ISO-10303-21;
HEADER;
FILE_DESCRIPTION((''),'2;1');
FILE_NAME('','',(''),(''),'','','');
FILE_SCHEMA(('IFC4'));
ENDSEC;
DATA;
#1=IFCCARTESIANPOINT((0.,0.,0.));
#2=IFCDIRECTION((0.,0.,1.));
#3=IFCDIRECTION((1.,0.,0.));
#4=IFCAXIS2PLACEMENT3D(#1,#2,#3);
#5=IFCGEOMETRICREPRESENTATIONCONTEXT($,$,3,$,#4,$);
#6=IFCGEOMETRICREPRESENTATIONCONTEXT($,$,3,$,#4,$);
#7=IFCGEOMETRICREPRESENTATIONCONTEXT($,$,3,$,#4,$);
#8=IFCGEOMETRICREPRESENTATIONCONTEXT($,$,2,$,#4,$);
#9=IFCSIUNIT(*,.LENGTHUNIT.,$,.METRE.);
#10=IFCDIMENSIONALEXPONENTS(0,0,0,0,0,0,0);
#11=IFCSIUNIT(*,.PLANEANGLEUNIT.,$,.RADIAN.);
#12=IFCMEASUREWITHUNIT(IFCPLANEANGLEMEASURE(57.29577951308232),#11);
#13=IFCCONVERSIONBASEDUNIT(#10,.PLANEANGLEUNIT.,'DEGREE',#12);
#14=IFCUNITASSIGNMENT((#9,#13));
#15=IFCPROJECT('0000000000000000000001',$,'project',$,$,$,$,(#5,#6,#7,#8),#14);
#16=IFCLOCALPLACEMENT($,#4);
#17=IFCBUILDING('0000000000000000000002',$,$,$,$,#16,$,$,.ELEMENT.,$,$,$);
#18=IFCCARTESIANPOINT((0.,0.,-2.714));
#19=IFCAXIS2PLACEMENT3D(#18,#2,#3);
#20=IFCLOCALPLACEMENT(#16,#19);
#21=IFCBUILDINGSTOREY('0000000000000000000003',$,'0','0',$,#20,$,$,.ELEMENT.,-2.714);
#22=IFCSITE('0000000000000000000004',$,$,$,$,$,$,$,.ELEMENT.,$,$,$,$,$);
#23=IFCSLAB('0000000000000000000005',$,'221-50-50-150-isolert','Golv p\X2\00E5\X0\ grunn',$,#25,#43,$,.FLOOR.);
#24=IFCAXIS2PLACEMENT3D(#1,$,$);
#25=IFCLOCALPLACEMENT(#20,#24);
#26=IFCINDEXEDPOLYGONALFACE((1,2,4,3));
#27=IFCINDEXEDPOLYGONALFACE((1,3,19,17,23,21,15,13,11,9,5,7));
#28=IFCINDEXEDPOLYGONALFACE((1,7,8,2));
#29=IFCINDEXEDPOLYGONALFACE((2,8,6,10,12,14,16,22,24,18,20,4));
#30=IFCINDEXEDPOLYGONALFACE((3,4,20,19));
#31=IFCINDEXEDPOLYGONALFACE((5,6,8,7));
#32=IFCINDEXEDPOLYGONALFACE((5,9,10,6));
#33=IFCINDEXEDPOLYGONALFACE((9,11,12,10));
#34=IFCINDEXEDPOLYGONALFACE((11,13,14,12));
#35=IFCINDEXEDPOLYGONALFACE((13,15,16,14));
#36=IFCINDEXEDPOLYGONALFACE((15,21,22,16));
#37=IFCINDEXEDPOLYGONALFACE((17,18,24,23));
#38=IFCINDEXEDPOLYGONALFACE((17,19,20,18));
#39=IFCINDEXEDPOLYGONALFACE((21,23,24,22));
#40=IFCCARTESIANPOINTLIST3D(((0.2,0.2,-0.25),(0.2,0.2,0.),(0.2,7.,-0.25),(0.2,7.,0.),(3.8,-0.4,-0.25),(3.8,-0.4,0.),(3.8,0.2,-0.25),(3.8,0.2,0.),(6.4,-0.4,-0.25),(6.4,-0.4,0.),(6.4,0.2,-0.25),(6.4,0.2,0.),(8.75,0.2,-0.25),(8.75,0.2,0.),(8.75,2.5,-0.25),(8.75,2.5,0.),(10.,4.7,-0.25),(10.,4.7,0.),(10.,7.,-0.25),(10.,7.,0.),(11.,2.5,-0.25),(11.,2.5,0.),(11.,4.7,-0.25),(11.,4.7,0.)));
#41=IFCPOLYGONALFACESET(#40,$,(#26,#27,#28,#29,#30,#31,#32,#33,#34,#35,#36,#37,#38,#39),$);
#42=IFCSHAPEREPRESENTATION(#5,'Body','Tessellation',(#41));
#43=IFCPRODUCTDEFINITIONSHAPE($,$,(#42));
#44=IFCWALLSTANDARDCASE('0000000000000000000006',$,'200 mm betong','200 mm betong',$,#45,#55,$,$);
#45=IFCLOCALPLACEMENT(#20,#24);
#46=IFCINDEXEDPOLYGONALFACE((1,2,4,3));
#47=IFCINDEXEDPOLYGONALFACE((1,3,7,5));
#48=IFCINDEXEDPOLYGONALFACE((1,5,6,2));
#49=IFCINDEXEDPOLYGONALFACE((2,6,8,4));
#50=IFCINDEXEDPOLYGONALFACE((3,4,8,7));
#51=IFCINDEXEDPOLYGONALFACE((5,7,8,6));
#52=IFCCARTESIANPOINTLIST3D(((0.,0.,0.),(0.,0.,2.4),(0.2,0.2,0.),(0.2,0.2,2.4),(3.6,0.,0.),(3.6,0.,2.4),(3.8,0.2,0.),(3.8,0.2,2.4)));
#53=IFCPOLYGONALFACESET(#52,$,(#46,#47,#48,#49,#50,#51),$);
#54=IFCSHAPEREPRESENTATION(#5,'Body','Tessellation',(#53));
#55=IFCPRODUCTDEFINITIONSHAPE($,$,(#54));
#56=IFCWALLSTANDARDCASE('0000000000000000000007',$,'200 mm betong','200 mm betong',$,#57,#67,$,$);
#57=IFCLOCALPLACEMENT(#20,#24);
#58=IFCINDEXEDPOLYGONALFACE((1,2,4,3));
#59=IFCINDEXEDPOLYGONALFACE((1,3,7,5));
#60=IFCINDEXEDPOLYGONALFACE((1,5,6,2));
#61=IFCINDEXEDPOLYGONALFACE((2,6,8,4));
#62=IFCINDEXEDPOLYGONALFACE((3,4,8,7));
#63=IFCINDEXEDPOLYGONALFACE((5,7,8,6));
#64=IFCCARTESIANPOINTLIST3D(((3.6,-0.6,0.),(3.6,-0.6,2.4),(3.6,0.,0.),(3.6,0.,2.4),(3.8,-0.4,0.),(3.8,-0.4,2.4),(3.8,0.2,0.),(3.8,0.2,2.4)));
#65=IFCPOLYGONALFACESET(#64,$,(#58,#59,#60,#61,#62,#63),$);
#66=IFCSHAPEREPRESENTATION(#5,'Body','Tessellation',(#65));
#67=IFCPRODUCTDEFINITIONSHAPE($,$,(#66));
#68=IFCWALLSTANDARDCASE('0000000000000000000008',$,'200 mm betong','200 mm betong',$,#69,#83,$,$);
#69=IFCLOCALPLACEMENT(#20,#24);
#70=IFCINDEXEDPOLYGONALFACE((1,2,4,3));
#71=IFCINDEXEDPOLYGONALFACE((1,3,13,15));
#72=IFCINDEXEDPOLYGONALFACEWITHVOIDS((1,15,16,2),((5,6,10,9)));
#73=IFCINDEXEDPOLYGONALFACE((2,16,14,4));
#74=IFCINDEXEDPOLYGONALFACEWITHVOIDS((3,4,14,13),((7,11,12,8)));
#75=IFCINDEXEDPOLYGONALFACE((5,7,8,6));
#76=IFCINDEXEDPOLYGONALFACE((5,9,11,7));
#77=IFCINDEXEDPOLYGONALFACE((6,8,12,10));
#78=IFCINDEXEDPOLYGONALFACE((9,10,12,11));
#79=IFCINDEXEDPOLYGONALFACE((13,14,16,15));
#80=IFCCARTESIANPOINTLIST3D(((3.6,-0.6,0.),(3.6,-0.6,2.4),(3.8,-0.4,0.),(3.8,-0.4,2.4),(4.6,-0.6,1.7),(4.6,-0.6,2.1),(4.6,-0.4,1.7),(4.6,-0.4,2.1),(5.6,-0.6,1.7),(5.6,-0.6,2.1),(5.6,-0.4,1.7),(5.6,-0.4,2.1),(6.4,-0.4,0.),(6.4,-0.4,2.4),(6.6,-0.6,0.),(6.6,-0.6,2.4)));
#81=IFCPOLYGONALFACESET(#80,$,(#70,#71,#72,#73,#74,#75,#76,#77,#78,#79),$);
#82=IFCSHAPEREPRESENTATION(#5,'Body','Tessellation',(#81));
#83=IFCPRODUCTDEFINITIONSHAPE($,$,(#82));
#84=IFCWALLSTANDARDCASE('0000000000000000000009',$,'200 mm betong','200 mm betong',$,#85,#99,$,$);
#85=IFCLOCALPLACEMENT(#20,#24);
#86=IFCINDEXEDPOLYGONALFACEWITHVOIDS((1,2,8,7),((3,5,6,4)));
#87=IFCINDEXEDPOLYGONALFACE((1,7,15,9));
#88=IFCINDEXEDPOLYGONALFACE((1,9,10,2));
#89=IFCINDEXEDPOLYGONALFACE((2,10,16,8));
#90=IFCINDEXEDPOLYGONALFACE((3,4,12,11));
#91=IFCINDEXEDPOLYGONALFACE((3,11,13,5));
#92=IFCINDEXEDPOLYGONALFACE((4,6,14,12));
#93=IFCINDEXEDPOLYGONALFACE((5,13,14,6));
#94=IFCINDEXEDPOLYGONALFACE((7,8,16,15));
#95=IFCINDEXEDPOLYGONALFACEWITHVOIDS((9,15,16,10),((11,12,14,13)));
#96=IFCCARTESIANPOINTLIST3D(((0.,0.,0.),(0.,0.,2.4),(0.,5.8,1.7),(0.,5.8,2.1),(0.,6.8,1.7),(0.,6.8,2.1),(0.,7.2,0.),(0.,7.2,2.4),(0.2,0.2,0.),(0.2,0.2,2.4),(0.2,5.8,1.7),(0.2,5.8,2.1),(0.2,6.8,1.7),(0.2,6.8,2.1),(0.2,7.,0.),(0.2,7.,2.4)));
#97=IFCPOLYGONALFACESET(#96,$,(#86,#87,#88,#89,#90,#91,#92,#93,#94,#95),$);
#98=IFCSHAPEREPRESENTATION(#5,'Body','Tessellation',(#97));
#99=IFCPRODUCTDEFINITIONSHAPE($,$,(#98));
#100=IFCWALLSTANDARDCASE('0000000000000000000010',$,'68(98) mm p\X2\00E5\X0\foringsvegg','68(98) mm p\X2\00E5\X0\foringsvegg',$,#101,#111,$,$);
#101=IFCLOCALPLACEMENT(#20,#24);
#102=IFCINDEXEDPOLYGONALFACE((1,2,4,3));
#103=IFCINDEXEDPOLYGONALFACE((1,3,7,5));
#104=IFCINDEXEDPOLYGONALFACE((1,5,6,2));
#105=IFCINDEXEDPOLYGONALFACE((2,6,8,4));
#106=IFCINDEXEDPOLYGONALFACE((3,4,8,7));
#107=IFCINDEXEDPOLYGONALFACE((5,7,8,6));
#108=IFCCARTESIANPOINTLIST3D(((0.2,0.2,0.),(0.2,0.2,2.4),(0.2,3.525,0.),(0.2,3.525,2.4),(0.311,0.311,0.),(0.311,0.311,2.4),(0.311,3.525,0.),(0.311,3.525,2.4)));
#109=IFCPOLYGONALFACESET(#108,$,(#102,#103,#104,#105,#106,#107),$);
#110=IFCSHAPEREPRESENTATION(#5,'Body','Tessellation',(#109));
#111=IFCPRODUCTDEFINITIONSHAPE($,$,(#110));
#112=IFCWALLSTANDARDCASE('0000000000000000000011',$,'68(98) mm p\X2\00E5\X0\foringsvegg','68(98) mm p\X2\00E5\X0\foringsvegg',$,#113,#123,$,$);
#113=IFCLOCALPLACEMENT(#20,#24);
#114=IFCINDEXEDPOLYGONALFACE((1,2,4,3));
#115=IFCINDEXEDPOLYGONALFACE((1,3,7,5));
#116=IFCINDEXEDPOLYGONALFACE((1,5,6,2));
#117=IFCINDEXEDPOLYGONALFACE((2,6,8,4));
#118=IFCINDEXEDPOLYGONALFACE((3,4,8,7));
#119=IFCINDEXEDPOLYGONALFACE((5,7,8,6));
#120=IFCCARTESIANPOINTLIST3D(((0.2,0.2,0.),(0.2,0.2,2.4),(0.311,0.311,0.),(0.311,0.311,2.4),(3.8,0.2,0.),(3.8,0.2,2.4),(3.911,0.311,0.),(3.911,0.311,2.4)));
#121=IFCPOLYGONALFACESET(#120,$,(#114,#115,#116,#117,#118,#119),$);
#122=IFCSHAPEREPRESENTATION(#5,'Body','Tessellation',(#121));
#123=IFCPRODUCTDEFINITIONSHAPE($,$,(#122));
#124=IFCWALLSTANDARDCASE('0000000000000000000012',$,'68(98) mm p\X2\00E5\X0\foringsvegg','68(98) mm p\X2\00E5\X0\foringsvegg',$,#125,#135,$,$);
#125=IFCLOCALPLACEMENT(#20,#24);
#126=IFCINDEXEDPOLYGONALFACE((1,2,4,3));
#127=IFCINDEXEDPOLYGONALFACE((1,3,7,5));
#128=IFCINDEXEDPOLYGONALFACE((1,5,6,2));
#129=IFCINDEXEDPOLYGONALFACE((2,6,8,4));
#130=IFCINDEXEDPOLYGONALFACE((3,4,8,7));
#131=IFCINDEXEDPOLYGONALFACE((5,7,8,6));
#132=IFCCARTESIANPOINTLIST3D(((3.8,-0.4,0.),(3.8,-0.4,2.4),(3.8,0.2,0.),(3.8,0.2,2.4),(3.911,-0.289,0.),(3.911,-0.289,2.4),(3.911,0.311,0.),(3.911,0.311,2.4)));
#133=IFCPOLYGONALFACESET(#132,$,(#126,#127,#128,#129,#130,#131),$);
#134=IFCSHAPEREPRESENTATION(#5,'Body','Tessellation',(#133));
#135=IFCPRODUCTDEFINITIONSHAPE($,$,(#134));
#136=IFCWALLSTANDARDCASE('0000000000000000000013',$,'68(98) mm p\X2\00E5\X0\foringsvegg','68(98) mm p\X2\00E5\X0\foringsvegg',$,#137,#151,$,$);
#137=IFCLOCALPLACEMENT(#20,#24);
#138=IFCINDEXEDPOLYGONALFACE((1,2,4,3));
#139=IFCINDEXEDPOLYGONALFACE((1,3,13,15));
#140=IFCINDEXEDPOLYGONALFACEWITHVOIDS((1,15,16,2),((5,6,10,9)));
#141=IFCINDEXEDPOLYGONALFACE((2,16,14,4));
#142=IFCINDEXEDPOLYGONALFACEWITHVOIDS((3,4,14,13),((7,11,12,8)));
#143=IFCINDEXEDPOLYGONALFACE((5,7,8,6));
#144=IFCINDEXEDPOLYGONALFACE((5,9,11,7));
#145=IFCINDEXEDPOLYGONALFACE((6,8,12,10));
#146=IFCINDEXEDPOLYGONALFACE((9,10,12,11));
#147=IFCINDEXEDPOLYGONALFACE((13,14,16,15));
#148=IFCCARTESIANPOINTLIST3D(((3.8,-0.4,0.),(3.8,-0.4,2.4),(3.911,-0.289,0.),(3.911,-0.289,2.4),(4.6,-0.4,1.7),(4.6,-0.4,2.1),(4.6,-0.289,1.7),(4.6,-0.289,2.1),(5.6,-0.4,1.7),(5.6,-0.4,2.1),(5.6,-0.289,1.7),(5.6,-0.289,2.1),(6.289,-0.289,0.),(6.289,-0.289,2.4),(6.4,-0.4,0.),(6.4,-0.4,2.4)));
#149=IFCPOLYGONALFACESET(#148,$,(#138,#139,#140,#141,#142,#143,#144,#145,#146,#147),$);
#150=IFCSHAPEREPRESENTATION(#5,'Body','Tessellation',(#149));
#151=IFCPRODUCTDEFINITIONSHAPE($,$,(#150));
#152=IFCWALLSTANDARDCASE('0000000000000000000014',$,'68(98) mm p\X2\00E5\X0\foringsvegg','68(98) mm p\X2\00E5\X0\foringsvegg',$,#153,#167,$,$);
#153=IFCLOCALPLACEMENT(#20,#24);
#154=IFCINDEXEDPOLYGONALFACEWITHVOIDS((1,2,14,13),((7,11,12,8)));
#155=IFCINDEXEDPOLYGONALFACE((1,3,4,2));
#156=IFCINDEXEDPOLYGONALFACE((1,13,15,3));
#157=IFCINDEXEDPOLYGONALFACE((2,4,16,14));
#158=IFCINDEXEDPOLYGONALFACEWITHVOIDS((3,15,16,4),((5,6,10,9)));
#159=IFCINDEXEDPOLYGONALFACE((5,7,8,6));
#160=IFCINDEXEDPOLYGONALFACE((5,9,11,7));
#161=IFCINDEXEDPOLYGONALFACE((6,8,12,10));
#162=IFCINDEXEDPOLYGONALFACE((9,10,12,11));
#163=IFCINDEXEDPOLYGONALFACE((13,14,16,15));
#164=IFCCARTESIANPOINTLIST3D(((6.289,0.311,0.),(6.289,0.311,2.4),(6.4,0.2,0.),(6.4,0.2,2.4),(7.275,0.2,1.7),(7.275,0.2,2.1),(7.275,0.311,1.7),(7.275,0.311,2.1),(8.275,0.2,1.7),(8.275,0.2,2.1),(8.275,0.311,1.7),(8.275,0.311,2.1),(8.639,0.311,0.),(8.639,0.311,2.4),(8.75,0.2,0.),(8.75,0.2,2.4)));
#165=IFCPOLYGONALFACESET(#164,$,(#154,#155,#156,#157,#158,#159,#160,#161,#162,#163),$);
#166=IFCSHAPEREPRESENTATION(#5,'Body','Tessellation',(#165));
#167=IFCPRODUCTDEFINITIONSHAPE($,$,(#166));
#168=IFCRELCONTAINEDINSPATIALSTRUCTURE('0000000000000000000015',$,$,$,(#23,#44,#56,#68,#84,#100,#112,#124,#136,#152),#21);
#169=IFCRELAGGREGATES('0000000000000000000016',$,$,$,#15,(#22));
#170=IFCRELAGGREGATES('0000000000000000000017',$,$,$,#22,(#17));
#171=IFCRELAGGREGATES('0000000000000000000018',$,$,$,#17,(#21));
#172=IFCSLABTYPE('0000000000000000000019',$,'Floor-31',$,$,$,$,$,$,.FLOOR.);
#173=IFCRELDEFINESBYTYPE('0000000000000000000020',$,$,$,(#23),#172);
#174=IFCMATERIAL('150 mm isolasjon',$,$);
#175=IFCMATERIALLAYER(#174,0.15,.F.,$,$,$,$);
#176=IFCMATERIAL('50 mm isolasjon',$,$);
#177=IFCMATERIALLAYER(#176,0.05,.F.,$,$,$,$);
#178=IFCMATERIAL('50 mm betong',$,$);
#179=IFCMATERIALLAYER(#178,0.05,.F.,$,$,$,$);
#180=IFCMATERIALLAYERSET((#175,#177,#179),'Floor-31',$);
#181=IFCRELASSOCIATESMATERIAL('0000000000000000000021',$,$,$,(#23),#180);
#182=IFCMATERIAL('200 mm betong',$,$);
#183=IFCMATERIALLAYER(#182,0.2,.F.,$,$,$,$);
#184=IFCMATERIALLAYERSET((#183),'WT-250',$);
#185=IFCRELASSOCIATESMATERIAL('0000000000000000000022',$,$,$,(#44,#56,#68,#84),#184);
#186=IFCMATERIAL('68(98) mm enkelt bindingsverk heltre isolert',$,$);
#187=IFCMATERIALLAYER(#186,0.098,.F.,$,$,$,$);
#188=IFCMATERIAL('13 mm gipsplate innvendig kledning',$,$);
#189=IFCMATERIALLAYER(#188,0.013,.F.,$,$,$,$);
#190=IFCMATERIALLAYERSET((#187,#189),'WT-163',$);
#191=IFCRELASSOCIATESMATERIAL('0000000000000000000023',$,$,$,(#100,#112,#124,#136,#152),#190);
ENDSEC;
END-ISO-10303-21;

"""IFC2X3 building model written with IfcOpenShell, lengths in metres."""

from ifc_helpers import new_model, entity, si_unit, converted_unit, frame, origin_with_axes, place, context, project, spatial, polyline, outline, extrude, material, layer, layer_set, layer_usage, type_object, element, save


model = new_model("IFC2X3")

# Units and contexts
context_of_model_1 = context(None, 3, world=origin_with_axes())
context_of_model_2 = context(None, 3, world=origin_with_axes())
context_of_model_3 = context(None, 3, world=origin_with_axes())
context_of_model_4 = context(None, 2, world=origin_with_axes())
ifc_project = project(units=[si_unit("LENGTHUNIT", "METRE"), converted_unit("PLANEANGLEUNIT", "DEGREE", entity("IfcPlaneAngleMeasure", 57.29577951308232), si_unit("PLANEANGLEUNIT", "RADIAN"), dimensions=[0, 0, 0, 0, 0, 0, 0])], contexts=[context_of_model_1, context_of_model_2, context_of_model_3, context_of_model_4])

# Site, building, storey
site = spatial("IfcSite", under=ifc_project, CompositionType="ELEMENT")
building_placement = place(None, origin_with_axes())
building = spatial("IfcBuilding", under=site, at=building_placement, CompositionType="ELEMENT")
storey_placement = place(building_placement, frame((0.0, 0.0, -2.714), z_axis=(0.0, 0.0, 1.0), x_axis=(1.0, 0.0, 0.0)))
storey = spatial("IfcBuildingStorey", under=building, at=storey_placement, Name="0", Description="0", CompositionType="ELEMENT", Elevation=-2.714)

# Slab
ifc_material_1 = material(Name="150 mm isolasjon")
ifc_layer_1 = layer(ifc_material_1, 0.15, ventilated=False)
ifc_material_2 = material(Name="50 mm isolasjon")
ifc_layer_2 = layer(ifc_material_2, 0.05, ventilated=False)
ifc_material_3 = material(Name="50 mm betong")
ifc_layer_3 = layer(ifc_material_3, 0.05, ventilated=False)
ifc_layer_set_1 = layer_set([ifc_layer_1, ifc_layer_2, ifc_layer_3], Name="Floor-31")
ifc_layer_usage_1 = layer_usage(ifc_layer_set_1, "AXIS3", "NEGATIVE", 0.0)
slab_type = type_object("IfcSlabType", Name="Floor-31", PredefinedType="FLOOR")
slab_placement = place(storey_placement, frame((0.2, 0.2, -0.25), z_axis=(0.0, 0.0, 1.0), x_axis=(1.0, 0.0, 0.0)))
element("IfcSlab", 1, at=slab_placement, inside=storey, type_object=slab_type, material=ifc_layer_usage_1, Name="221-50-50-150-isolert", Description="Golv på grunn", PredefinedType="FLOOR", context=context_of_model_1, shape_type="SweptSolid", body=[
    extrude(outline(polyline([(0.0, 0.0), (3.6, 0.0), (3.6, 0.6), (6.2, 0.6), (6.2, 0.0), (8.55, 0.0), (8.55, -2.3), (10.8, -2.3), (10.8, -4.5), (9.8, -4.5), (9.8, -6.8), (0.0, -6.8), (0.0, 0.0)])), frame((0.0, 0.0, 0.0), z_axis=(0.0, 0.0, -1.0), x_axis=(1.0, 0.0, 0.0)), (0.0, 0.0, -1.0), 0.25),
])

# Walls
ifc_material_4 = material(Name="200 mm betong")
ifc_layer_4 = layer(ifc_material_4, 0.2, ventilated=False)
ifc_layer_set_2 = layer_set([ifc_layer_4], Name="WT-250")
ifc_layer_usage_2 = layer_usage(ifc_layer_set_2, "AXIS2", "POSITIVE", 0.0)
wall_1_placement = place(storey_placement, frame((0.0, 0.0, 0.0), z_axis=(0.0, 0.0, 1.0), x_axis=(1.0, 0.0, 0.0)))
element("IfcWallStandardCase", 2, at=wall_1_placement, inside=storey, material=ifc_layer_usage_2, Name="200 mm betong", Description="200 mm betong", context=context_of_model_1, shape_type="SweptSolid", body=[
    extrude(outline(polyline([(0.0, 0.0), (3.6, 0.0), (3.8, 0.2), (0.2, 0.2), (0.0, 0.0)])), frame((0.0, 0.0, 0.0), z_axis=(0.0, 0.0, 1.0), x_axis=(1.0, 0.0, 0.0)), (0.0, 0.0, 1.0), 2.4),
])
wall_2_placement = place(storey_placement, frame((3.6, 0.0, 0.0), z_axis=(0.0, 0.0, 1.0), x_axis=(0.0, -1.0, 0.0)))
element("IfcWallStandardCase", 3, at=wall_2_placement, inside=storey, material=ifc_layer_usage_2, Name="200 mm betong", Description="200 mm betong", context=context_of_model_1, shape_type="SweptSolid", body=[
    extrude(outline(polyline([(0.0, 0.0), (0.6, 0.0), (0.4, 0.2), (-0.2, 0.2), (0.0, 0.0)])), frame((0.0, 0.0, 0.0), z_axis=(0.0, 0.0, 1.0), x_axis=(1.0, 0.0, 0.0)), (0.0, 0.0, 1.0), 2.4),
])

# Walls, openings
wall_3_placement = place(storey_placement, frame((3.6, -0.6, 0.0), z_axis=(0.0, 0.0, 1.0), x_axis=(1.0, 0.0, 0.0)))
wall_3 = element("IfcWallStandardCase", 4, at=wall_3_placement, inside=storey, material=ifc_layer_usage_2, Name="200 mm betong", Description="200 mm betong", context=context_of_model_1, shape_type="SweptSolid", body=[
    extrude(outline(polyline([(0.0, 0.0), (3.0, 0.0), (2.8, 0.2), (0.2, 0.2), (0.0, 0.0)])), frame((0.0, 0.0, 0.0), z_axis=(0.0, 0.0, 1.0), x_axis=(1.0, 0.0, 0.0)), (0.0, 0.0, 1.0), 2.4),
])
opening_1_placement = place(wall_3_placement, frame((1.0, 0.0, 1.7), z_axis=(0.0, 0.0, 1.0), x_axis=(1.0, 0.0, 0.0)))
element("IfcOpeningElement", 5, at=opening_1_placement, inside=storey, cuts=wall_3, context=context_of_model_1, shape_type="SweptSolid", body=[
    extrude(outline(polyline([(0.0, 0.0), (0.4, 0.0), (0.4, 1.0), (0.0, 1.0), (0.0, 0.0)])), frame((0.0, 0.0, 0.0), z_axis=(0.0, 1.0, 0.0), x_axis=(0.0, 0.0, 1.0)), (0.0, 0.0, 1.0), 0.2),
])
wall_4_placement = place(storey_placement, frame((0.0, 7.2, 0.0), z_axis=(0.0, 0.0, 1.0), x_axis=(0.0, -1.0, 0.0)))
wall_4 = element("IfcWallStandardCase", 6, at=wall_4_placement, inside=storey, material=ifc_layer_usage_2, Name="200 mm betong", Description="200 mm betong", context=context_of_model_1, shape_type="SweptSolid", body=[
    extrude(outline(polyline([(0.0, 0.0), (7.2, 0.0), (7.0, 0.2), (0.2, 0.2), (0.0, 0.0)])), frame((0.0, 0.0, 0.0), z_axis=(0.0, 0.0, 1.0), x_axis=(1.0, 0.0, 0.0)), (0.0, 0.0, 1.0), 2.4),
])
opening_2_placement = place(wall_4_placement, frame((0.4, 0.0, 1.7), z_axis=(0.0, 0.0, 1.0), x_axis=(1.0, 0.0, 0.0)))
element("IfcOpeningElement", 7, at=opening_2_placement, inside=storey, cuts=wall_4, context=context_of_model_1, shape_type="SweptSolid", body=[
    extrude(outline(polyline([(0.0, 0.0), (0.4, 0.0), (0.4, 1.0), (0.0, 1.0), (0.0, 0.0)])), frame((0.0, 0.0, 0.0), z_axis=(0.0, 1.0, 0.0), x_axis=(0.0, 0.0, 1.0)), (0.0, 0.0, 1.0), 0.2),
])

# Walls
ifc_material_5 = material(Name="68(98) mm enkelt bindingsverk heltre isolert")
ifc_layer_5 = layer(ifc_material_5, 0.098, ventilated=False)
ifc_material_6 = material(Name="13 mm gipsplate innvendig kledning")
ifc_layer_6 = layer(ifc_material_6, 0.013, ventilated=False)
ifc_layer_set_3 = layer_set([ifc_layer_5, ifc_layer_6], Name="WT-163")
ifc_layer_usage_3 = layer_usage(ifc_layer_set_3, "AXIS2", "POSITIVE", 0.0)
wall_5_placement = place(storey_placement, frame((0.2, 3.525, 0.0), z_axis=(0.0, 0.0, 1.0), x_axis=(0.0, -1.0, 0.0)))
element("IfcWallStandardCase", 8, at=wall_5_placement, inside=storey, material=ifc_layer_usage_3, Name="68(98) mm påforingsvegg", Description="68(98) mm påforingsvegg", context=context_of_model_1, shape_type="SweptSolid", body=[
    extrude(outline(polyline([(0.0, 0.0), (3.325, 0.0), (3.214, 0.111), (0.0, 0.111), (0.0, 0.0)])), frame((0.0, 0.0, 0.0), z_axis=(0.0, 0.0, 1.0), x_axis=(1.0, 0.0, 0.0)), (0.0, 0.0, 1.0), 2.4),
])
wall_6_placement = place(storey_placement, frame((0.2, 0.2, 0.0), z_axis=(0.0, 0.0, 1.0), x_axis=(1.0, 0.0, 0.0)))
element("IfcWallStandardCase", 9, at=wall_6_placement, inside=storey, material=ifc_layer_usage_3, Name="68(98) mm påforingsvegg", Description="68(98) mm påforingsvegg", context=context_of_model_1, shape_type="SweptSolid", body=[
    extrude(outline(polyline([(0.0, 0.0), (3.6, 0.0), (3.711, 0.111), (0.111, 0.111), (0.0, 0.0)])), frame((0.0, 0.0, 0.0), z_axis=(0.0, 0.0, 1.0), x_axis=(1.0, 0.0, 0.0)), (0.0, 0.0, 1.0), 2.4),
])
wall_7_placement = place(storey_placement, frame((3.8, 0.2, 0.0), z_axis=(0.0, 0.0, 1.0), x_axis=(0.0, -1.0, 0.0)))
element("IfcWallStandardCase", 10, at=wall_7_placement, inside=storey, material=ifc_layer_usage_3, Name="68(98) mm påforingsvegg", Description="68(98) mm påforingsvegg", context=context_of_model_1, shape_type="SweptSolid", body=[
    extrude(outline(polyline([(0.0, 0.0), (0.6, 0.0), (0.489, 0.111), (-0.111, 0.111), (0.0, 0.0)])), frame((0.0, 0.0, 0.0), z_axis=(0.0, 0.0, 1.0), x_axis=(1.0, 0.0, 0.0)), (0.0, 0.0, 1.0), 2.4),
])

# Walls, openings
wall_8_placement = place(storey_placement, frame((3.8, -0.4, 0.0), z_axis=(0.0, 0.0, 1.0), x_axis=(1.0, 0.0, 0.0)))
wall_8 = element("IfcWallStandardCase", 11, at=wall_8_placement, inside=storey, material=ifc_layer_usage_3, Name="68(98) mm påforingsvegg", Description="68(98) mm påforingsvegg", context=context_of_model_1, shape_type="SweptSolid", body=[
    extrude(outline(polyline([(0.0, 0.0), (2.6, 0.0), (2.489, 0.111), (0.111, 0.111), (0.0, 0.0)])), frame((0.0, 0.0, 0.0), z_axis=(0.0, 0.0, 1.0), x_axis=(1.0, 0.0, 0.0)), (0.0, 0.0, 1.0), 2.4),
])
opening_3_placement = place(wall_8_placement, frame((0.8, 0.0, 1.7), z_axis=(0.0, 0.0, 1.0), x_axis=(1.0, 0.0, 0.0)))
element("IfcOpeningElement", 12, at=opening_3_placement, inside=storey, cuts=wall_8, context=context_of_model_1, shape_type="SweptSolid", body=[
    extrude(outline(polyline([(0.0, 0.0), (0.4, 0.0), (0.4, 1.0), (0.0, 1.0), (0.0, 0.0)])), frame((0.0, 0.0, 0.0), z_axis=(0.0, 1.0, 0.0), x_axis=(0.0, 0.0, 1.0)), (0.0, 0.0, 1.0), 0.111),
])
wall_9_placement = place(storey_placement, frame((6.4, 0.2, 0.0), z_axis=(0.0, 0.0, 1.0), x_axis=(1.0, 0.0, 0.0)))
wall_9 = element("IfcWallStandardCase", 13, at=wall_9_placement, inside=storey, material=ifc_layer_usage_3, Name="68(98) mm påforingsvegg", Description="68(98) mm påforingsvegg", context=context_of_model_1, shape_type="SweptSolid", body=[
    extrude(outline(polyline([(0.0, 0.0), (2.35, 0.0), (2.239, 0.111), (-0.111, 0.111), (0.0, 0.0)])), frame((0.0, 0.0, 0.0), z_axis=(0.0, 0.0, 1.0), x_axis=(1.0, -0.000001, 0.0)), (0.0, 0.0, 1.0), 2.4),
])
opening_4_placement = place(wall_9_placement, frame((0.875, 0.0, 1.7), z_axis=(0.0, 0.0, 1.0), x_axis=(1.0, 0.0, 0.0)))
element("IfcOpeningElement", 14, at=opening_4_placement, inside=storey, cuts=wall_9, context=context_of_model_1, shape_type="SweptSolid", body=[
    extrude(outline(polyline([(0.0, 0.0), (0.4, 0.0), (0.4, 1.0), (0.0, 1.0), (0.0, 0.0)])), frame((0.0, 0.0, 0.0), z_axis=(0.000001, 1.0, 0.0), x_axis=(0.0, 0.0, 1.0)), (0.0, -0.000001, 1.0), 0.111),
])

save(model, "model.ifc")
